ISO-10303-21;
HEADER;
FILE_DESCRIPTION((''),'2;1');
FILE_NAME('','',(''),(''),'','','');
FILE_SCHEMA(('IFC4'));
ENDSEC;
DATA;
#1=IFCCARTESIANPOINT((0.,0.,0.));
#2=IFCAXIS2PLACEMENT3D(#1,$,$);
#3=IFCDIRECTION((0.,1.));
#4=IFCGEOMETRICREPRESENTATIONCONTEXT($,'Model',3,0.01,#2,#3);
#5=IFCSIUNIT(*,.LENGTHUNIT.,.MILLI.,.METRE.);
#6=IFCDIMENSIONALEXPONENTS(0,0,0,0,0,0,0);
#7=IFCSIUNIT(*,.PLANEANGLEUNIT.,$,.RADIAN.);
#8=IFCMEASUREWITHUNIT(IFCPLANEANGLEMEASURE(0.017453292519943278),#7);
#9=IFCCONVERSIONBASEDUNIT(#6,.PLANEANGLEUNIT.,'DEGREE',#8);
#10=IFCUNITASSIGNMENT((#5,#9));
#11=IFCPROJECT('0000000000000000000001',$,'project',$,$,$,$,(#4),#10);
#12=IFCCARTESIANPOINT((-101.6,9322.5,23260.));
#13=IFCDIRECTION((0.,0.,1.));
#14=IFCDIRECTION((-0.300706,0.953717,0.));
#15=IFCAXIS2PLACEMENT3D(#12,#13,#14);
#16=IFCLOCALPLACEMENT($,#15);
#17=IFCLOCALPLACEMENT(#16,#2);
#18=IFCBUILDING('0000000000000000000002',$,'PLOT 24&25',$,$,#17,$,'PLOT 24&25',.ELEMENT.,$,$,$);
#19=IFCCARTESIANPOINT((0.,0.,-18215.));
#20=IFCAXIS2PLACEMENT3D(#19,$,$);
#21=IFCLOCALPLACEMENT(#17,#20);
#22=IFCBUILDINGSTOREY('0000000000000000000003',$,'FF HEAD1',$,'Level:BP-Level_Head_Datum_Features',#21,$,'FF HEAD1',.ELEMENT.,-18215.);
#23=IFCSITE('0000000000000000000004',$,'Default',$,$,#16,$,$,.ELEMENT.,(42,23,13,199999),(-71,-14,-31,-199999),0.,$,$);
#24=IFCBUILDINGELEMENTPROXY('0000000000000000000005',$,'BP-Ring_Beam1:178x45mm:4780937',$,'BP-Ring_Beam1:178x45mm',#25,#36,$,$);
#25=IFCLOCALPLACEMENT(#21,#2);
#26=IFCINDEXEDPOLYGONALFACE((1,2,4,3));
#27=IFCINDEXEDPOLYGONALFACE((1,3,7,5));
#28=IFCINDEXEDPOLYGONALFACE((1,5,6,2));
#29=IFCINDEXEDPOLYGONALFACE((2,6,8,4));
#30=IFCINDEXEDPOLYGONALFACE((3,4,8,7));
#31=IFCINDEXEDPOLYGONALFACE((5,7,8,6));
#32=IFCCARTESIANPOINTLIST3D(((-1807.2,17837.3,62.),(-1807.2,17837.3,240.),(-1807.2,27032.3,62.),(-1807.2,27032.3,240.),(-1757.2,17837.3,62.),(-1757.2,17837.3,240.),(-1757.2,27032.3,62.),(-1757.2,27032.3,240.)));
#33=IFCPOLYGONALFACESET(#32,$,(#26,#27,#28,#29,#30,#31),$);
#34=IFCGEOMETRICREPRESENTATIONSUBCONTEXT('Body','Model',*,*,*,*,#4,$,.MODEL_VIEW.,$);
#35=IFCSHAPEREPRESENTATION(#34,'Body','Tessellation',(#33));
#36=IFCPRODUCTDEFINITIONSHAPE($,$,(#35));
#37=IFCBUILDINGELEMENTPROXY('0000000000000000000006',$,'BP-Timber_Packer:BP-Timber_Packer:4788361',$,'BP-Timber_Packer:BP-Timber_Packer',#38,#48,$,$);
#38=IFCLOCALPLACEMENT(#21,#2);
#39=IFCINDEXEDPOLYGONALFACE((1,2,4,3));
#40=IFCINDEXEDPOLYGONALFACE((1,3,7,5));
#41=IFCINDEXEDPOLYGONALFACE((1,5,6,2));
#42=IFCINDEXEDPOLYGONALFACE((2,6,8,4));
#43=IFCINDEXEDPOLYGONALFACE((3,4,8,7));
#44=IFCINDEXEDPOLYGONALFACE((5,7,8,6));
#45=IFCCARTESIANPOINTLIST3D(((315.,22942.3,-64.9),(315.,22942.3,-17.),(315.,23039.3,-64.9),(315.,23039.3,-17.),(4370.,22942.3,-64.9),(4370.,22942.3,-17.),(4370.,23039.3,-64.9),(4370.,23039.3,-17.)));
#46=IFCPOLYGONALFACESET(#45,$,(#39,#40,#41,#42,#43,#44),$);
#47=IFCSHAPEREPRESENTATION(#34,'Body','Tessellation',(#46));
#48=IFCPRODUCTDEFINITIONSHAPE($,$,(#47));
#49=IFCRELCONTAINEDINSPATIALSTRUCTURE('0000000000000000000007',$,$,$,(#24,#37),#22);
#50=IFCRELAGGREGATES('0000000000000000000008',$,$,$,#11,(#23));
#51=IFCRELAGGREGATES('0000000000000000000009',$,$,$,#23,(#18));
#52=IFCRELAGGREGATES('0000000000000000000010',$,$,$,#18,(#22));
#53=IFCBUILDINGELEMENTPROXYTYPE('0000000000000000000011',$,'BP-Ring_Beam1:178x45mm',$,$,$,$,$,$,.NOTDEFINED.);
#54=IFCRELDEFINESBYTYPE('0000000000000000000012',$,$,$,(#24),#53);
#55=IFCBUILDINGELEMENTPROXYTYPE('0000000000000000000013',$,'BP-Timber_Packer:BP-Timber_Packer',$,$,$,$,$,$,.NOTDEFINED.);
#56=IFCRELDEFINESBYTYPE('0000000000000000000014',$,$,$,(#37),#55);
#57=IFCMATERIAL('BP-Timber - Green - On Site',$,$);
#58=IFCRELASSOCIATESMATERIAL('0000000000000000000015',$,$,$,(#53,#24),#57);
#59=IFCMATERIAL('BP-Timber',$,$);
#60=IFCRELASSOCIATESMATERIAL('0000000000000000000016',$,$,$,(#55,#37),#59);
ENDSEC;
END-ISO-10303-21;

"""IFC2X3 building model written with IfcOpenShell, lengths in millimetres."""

from ifc_helpers import new_model, entity, si_unit, converted_unit, direction, frame, origin, origin_2d_with_axis, place, context, subcontext, project, spatial, rectangle, extrude, source, transform, mapped, material, type_object, type_shapes, element, save


model = new_model("IFC2X3")

# Units and contexts
model_context = context("Model", 3, precision=0.01, world=origin(), true_north=direction((0.0, 1.0)))
body_context = subcontext(model_context, "Body", "Model", "MODEL_VIEW")
ifc_project = project(units=[si_unit("LENGTHUNIT", "METRE", prefix="MILLI"), converted_unit("PLANEANGLEUNIT", "DEGREE", entity("IfcPlaneAngleMeasure", 0.017453292519943278), si_unit("PLANEANGLEUNIT", "RADIAN"), dimensions=[0, 0, 0, 0, 0, 0, 0])], contexts=[model_context])

# Site, building, storey
site_placement = place(None, frame((-101.6, 9322.5, 23260.0), z_axis=(0.0, 0.0, 1.0), x_axis=(-0.300706, 0.953717, 0.0)))
site = spatial("IfcSite", under=ifc_project, at=site_placement, Name="Default", CompositionType="ELEMENT", RefLatitude=(42, 23, 13, 199999), RefLongitude=(-71, -14, -31, -199999), RefElevation=0.0)
building_placement = place(site_placement, origin())
building = spatial("IfcBuilding", under=site, at=building_placement, Name="PLOT 24&25", LongName="PLOT 24&25", CompositionType="ELEMENT")
storey_placement = place(building_placement, frame((0.0, 0.0, -18215.0)))
storey = spatial("IfcBuildingStorey", under=building, at=storey_placement, Name="FF HEAD1", ObjectType="Level:BP-Level_Head_Datum_Features", LongName="FF HEAD1", CompositionType="ELEMENT", Elevation=-18215.0)

# Building element proxies
ifc_material_1 = material(Name="BP-Timber")
ifc_material_2 = material(Name="BP-Timber - Green - On Site")
building_element_proxy_type_1 = type_object("IfcBuildingElementProxyType", Name="BP-Ring_Beam1:178x45mm", PredefinedType="NOTDEFINED", material=ifc_material_2)
shared_shape_1 = source(origin(), body_context, "Body", "SweptSolid", [
    extrude(rectangle(XDim=9195.0, YDim=50.0, at=origin_2d_with_axis()), frame((0.0, -25.0, -178.0), z_axis=(0.0, 0.0, 1.0), x_axis=(-1.0, 0.0, 0.0)), (0.0, 0.0, 1.0), 178.0),
])
type_shapes(building_element_proxy_type_1, [shared_shape_1])
proxy_1_placement = place(storey_placement, frame((-1757.2, 22434.8, 240.0), z_axis=(0.0, 0.0, 1.0), x_axis=(0.0, -1.0, 0.0)))
element("IfcBuildingElementProxy", 1, at=proxy_1_placement, inside=storey, type_object=building_element_proxy_type_1, material=ifc_material_2, Name="BP-Ring_Beam1:178x45mm:4780937", ObjectType="BP-Ring_Beam1:178x45mm", context=body_context, shape_type="MappedRepresentation", body=[
    mapped(shared_shape_1, transform((0.0, 0.0, 0.0), scale=1.0)),
])
building_element_proxy_type_2 = type_object("IfcBuildingElementProxyType", Name="BP-Timber_Packer:BP-Timber_Packer", PredefinedType="NOTDEFINED", material=ifc_material_1)
shared_shape_2 = source(origin(), body_context, "Body", "SweptSolid", [
    extrude(rectangle(XDim=4055.0, YDim=97.0, at=origin_2d_with_axis()), frame((0.0, 0.0, 0.0), z_axis=(0.0, 0.0, 1.0), x_axis=(-1.0, 0.0, 0.0)), (0.0, 0.0, 1.0), 47.9),
])
type_shapes(building_element_proxy_type_2, [shared_shape_2])
proxy_2_placement = place(storey_placement, frame((2342.5, 22990.8, -64.9)))
element("IfcBuildingElementProxy", 2, at=proxy_2_placement, inside=storey, type_object=building_element_proxy_type_2, material=ifc_material_1, Name="BP-Timber_Packer:BP-Timber_Packer:4788361", ObjectType="BP-Timber_Packer:BP-Timber_Packer", context=body_context, shape_type="MappedRepresentation", body=[
    mapped(shared_shape_2, transform((0.0, 0.0, 0.0), scale=1.0)),
])

save(model, "model.ifc")
